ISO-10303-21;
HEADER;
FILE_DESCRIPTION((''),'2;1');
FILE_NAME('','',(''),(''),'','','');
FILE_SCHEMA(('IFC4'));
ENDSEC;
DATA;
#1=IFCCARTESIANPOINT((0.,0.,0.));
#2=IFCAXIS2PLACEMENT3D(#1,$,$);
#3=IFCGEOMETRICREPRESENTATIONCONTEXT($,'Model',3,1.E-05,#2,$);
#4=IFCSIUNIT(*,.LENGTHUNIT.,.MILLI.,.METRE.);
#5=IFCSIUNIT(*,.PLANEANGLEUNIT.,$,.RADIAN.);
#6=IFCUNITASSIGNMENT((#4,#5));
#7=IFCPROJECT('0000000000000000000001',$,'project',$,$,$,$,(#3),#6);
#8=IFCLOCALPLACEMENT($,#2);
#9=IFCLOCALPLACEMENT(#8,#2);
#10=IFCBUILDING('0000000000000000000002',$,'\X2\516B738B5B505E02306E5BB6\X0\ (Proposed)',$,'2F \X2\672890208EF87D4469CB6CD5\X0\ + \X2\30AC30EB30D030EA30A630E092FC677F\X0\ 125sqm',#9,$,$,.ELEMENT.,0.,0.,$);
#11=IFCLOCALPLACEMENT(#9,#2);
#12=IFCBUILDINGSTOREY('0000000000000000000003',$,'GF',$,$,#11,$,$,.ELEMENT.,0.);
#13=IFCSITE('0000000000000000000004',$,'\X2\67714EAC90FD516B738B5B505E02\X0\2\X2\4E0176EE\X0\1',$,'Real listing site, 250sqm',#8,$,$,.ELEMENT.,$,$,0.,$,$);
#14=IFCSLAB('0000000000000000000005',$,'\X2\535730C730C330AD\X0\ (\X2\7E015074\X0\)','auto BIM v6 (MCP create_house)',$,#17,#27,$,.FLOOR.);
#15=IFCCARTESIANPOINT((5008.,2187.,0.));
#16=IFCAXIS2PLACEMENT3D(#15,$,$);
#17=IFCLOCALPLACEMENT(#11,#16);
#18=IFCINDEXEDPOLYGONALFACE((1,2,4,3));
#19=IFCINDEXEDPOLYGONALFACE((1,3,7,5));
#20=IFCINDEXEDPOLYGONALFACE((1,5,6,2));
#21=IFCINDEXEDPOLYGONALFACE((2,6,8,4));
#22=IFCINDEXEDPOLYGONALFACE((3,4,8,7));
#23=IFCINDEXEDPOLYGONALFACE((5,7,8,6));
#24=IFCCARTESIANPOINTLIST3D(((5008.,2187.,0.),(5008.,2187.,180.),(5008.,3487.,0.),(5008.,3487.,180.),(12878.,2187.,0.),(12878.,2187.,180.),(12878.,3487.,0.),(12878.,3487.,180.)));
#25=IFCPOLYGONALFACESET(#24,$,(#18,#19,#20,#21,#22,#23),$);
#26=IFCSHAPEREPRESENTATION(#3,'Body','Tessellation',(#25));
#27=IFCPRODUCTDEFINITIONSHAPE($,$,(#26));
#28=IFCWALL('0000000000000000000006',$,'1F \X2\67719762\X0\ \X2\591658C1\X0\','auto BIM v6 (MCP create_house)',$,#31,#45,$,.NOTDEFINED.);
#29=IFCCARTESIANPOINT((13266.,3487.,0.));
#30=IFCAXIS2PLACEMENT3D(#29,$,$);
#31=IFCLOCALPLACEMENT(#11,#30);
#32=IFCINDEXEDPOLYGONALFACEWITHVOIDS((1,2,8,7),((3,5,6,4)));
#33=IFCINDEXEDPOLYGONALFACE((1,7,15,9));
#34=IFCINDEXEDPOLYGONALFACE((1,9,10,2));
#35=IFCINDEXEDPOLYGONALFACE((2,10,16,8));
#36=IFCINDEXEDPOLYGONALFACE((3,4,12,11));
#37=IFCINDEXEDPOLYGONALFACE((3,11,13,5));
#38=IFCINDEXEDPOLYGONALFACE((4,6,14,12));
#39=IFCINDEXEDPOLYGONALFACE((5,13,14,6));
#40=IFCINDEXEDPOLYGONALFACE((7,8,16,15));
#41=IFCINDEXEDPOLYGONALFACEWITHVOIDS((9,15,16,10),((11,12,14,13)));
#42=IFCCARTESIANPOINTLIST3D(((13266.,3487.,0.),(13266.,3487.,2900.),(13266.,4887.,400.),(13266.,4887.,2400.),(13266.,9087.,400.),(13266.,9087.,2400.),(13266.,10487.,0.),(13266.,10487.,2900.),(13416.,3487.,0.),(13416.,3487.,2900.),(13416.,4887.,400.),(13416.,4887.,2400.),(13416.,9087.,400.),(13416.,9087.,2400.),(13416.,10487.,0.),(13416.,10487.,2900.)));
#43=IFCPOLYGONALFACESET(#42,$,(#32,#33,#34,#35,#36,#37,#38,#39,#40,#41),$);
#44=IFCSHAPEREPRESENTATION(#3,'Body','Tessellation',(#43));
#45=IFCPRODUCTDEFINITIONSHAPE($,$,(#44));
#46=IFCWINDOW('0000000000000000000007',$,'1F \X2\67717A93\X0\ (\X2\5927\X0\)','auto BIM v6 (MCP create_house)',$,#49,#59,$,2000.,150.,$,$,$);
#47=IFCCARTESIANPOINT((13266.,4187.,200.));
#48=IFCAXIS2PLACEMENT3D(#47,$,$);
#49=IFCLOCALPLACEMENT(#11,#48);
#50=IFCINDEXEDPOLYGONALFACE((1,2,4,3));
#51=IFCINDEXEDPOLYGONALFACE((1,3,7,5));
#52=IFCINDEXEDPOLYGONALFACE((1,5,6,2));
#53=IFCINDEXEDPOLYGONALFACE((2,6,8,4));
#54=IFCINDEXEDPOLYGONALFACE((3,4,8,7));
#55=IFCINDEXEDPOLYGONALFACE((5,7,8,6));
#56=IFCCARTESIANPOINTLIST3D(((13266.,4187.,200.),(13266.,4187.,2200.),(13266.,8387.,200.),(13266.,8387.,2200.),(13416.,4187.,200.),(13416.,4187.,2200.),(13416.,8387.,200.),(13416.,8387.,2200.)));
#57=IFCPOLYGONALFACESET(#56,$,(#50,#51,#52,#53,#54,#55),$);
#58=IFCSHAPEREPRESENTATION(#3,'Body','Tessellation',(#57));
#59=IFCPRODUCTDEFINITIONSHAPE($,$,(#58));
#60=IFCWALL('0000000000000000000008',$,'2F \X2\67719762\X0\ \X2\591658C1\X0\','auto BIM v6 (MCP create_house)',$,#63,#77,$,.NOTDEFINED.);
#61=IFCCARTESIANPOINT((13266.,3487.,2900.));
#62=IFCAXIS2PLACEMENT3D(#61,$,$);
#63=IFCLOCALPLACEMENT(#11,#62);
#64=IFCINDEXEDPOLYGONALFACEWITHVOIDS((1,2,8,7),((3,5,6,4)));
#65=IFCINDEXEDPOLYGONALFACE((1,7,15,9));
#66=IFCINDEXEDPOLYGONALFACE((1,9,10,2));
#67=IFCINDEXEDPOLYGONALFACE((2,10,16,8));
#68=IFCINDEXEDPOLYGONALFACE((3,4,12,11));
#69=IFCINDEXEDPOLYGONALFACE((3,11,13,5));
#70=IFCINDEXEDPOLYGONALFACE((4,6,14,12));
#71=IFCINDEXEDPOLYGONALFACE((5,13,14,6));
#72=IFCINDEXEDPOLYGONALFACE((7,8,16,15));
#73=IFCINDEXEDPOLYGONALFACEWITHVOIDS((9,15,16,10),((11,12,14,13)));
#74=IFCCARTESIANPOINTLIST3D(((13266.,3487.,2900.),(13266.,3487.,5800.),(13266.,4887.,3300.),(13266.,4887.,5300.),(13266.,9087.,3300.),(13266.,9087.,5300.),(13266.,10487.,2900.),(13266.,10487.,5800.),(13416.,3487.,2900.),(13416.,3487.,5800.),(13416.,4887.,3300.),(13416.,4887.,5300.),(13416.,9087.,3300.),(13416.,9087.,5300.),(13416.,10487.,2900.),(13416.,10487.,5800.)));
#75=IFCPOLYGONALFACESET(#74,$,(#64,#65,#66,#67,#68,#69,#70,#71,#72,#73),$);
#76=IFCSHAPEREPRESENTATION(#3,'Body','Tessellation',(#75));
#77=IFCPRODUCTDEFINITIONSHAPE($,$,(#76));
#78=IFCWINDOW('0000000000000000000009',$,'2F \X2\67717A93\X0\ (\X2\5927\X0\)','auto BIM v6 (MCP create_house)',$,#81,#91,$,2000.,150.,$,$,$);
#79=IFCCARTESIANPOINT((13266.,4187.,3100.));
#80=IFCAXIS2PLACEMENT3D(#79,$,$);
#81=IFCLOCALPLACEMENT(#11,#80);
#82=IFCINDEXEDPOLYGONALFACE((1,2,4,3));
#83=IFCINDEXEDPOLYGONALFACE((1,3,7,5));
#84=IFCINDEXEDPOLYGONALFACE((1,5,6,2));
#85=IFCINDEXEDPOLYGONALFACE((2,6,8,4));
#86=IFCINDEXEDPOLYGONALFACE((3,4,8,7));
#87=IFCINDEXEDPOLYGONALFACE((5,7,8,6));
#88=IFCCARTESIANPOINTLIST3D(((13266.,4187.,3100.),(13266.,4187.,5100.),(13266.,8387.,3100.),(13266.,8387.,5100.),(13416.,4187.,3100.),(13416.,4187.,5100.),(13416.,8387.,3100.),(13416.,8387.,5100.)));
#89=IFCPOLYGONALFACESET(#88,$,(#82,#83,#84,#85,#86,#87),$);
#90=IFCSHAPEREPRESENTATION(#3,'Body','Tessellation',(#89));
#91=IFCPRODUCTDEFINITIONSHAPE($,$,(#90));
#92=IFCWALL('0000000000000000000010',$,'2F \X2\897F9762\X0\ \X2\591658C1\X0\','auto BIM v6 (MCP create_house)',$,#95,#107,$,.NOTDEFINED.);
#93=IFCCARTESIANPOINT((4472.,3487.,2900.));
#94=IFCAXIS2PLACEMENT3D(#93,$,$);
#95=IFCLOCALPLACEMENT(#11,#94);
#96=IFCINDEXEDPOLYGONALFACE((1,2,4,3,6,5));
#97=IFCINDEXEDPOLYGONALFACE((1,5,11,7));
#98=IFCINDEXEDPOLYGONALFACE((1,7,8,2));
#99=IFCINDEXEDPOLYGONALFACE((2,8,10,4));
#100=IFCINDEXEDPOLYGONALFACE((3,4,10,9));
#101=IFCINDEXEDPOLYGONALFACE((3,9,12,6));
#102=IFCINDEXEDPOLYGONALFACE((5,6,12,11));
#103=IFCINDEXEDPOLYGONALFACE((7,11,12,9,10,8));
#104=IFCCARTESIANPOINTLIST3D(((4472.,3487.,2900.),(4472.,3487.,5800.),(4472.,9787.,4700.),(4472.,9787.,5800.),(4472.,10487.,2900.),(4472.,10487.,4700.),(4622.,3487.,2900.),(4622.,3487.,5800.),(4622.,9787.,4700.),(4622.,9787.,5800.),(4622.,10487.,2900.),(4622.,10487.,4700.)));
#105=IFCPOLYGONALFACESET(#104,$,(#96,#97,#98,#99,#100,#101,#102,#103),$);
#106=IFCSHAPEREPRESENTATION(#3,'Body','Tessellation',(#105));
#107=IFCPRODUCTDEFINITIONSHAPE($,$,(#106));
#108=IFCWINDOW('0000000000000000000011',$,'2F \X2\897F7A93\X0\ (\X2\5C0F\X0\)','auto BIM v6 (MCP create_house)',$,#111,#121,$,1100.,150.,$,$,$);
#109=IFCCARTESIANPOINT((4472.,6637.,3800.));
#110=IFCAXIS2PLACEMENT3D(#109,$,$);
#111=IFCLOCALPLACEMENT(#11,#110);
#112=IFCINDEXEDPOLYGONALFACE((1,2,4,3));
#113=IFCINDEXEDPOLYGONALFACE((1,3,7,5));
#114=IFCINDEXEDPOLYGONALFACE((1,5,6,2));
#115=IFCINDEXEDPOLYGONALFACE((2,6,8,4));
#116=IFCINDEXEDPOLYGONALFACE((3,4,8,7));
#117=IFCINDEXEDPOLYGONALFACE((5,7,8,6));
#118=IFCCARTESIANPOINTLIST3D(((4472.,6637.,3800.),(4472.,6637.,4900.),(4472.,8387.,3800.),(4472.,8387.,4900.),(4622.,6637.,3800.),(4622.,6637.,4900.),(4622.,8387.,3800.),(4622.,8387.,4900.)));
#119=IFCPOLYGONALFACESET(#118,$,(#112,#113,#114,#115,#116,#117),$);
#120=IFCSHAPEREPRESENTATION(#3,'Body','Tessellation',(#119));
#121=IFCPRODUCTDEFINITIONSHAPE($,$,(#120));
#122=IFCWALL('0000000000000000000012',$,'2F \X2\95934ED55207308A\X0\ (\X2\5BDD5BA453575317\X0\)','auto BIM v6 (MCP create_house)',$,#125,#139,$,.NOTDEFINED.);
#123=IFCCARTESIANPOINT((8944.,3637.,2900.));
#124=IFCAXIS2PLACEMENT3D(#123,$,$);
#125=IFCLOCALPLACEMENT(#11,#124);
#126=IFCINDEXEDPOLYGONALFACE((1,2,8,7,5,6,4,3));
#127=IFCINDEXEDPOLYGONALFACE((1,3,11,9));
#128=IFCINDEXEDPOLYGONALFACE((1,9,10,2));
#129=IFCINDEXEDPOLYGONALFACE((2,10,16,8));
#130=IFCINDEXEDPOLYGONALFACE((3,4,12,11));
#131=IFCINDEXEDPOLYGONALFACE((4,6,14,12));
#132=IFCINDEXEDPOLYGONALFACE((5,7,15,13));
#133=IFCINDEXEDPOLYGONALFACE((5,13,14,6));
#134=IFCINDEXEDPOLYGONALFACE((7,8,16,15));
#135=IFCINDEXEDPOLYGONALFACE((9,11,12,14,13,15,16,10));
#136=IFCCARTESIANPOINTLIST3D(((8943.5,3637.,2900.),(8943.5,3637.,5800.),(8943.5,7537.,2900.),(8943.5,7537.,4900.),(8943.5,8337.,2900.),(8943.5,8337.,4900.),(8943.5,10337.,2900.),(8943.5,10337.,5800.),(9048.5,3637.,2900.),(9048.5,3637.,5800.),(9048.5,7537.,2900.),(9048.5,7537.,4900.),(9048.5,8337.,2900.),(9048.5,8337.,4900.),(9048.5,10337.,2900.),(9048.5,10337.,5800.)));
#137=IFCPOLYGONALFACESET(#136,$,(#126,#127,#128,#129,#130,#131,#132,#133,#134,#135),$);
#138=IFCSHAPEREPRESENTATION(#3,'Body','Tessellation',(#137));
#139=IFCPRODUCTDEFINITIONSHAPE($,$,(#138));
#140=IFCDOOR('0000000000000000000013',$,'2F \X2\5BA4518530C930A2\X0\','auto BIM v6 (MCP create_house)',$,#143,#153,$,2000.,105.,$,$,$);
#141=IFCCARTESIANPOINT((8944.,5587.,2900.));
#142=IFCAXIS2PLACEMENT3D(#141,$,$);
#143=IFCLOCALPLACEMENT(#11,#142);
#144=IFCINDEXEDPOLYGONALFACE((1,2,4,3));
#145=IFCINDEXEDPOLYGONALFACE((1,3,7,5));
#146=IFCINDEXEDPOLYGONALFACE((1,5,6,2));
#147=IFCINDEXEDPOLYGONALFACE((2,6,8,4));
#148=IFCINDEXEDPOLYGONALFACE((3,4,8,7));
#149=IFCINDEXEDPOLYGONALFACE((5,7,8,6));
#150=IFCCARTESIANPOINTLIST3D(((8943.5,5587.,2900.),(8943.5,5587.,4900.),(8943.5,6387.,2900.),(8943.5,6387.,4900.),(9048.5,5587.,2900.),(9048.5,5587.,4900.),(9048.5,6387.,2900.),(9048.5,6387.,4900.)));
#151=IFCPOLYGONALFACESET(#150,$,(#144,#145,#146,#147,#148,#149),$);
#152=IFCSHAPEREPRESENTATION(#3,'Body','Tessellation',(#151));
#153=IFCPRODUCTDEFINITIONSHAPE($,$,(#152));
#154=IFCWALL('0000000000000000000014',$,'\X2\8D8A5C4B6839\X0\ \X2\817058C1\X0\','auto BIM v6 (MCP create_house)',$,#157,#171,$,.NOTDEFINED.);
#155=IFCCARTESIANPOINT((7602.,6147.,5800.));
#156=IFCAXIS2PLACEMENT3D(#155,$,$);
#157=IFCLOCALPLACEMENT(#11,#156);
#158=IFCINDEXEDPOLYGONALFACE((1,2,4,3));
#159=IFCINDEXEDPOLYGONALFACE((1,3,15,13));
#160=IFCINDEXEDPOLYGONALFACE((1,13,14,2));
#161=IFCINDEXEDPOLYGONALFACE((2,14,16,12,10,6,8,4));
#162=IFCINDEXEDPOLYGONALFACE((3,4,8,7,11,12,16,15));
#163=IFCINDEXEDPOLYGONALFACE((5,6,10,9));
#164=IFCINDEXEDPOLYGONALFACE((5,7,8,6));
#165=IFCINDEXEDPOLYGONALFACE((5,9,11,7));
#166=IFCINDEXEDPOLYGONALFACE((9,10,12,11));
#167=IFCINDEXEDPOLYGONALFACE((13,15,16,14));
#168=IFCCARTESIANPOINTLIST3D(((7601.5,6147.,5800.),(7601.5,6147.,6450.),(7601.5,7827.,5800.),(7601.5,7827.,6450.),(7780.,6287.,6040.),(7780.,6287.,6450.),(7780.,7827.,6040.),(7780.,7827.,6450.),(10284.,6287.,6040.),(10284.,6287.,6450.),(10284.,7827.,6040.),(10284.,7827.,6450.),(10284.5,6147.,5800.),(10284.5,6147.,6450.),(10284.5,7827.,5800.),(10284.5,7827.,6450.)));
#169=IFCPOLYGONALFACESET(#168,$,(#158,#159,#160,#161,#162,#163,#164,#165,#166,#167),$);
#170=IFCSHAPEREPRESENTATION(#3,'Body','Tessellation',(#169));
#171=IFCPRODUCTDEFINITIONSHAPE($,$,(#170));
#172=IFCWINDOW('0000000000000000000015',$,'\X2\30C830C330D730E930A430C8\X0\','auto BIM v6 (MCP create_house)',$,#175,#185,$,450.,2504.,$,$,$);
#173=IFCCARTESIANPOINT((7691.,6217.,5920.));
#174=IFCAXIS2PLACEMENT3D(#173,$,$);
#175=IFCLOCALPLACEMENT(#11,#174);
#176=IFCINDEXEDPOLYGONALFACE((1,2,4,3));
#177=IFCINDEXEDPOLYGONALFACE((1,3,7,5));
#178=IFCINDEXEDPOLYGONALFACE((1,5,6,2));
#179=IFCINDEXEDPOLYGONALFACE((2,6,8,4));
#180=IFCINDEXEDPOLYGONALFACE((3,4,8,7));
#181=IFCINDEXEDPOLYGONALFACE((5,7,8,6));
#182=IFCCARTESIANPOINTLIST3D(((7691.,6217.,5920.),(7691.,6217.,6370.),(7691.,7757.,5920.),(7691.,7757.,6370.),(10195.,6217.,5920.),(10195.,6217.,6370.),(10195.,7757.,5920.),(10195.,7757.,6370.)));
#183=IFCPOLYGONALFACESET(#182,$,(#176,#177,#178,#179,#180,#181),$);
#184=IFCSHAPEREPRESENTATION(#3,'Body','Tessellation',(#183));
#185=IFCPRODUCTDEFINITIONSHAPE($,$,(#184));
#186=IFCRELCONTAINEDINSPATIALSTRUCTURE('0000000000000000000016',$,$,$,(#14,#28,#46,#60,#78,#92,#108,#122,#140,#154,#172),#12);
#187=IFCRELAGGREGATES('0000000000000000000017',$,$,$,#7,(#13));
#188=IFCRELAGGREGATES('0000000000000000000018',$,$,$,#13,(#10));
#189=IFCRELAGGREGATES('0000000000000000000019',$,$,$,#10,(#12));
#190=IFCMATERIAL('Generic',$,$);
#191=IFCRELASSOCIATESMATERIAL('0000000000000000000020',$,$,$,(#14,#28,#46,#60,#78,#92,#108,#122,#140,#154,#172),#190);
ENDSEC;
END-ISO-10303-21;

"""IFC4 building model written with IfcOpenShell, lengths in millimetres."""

from ifc_helpers import new_model, si_unit, frame, frame_2d, origin, place, context, project, spatial, rectangle, extrude, material, element, fill, save


model = new_model("IFC4")

# Units and contexts
model_context = context("Model", 3, precision=1e-05, world=origin())
ifc_project = project(units=[si_unit("LENGTHUNIT", "METRE", prefix="MILLI"), si_unit("PLANEANGLEUNIT", "RADIAN")], contexts=[model_context])

# Site, building, storey
site_placement = place(None, origin())
site = spatial("IfcSite", under=ifc_project, at=site_placement, Name="東京都八王子市2丁目1", ObjectType="Real listing site, 250sqm", CompositionType="ELEMENT", RefElevation=0.0)
building_placement = place(site_placement, origin())
building = spatial("IfcBuilding", under=site, at=building_placement, Name="八王子市の家 (Proposed)", ObjectType="2F 木造軸組構法 + ガルバリウム鋼板 125sqm", CompositionType="ELEMENT", ElevationOfRefHeight=0.0, ElevationOfTerrain=0.0)
storey_placement = place(building_placement, origin())
storey = spatial("IfcBuildingStorey", under=building, at=storey_placement, Name="GF", CompositionType="ELEMENT", Elevation=0.0)

# Slab
ifc_material = material(Name="Generic")
slab_placement = place(storey_placement, frame((5008.0, 2187.0, 0.0)))
element("IfcSlab", 1, at=slab_placement, inside=storey, material=ifc_material, Name="南デッキ (縁側)", Description="auto BIM v6 (MCP create_house)", PredefinedType="FLOOR", context=model_context, shape_type="SweptSolid", body=[
    extrude(rectangle(XDim=7870.0, YDim=1300.0, at=frame_2d((3935.0, 650.0))), frame((5008.0, 2187.0, 0.0)), (0.0, 0.0, 1.0), 180.0),
])

# Wall, opening, window
wall_1_placement = place(storey_placement, frame((13266.0, 3487.0, 0.0)))
wall_1 = element("IfcWall", 2, at=wall_1_placement, inside=storey, material=ifc_material, Name="1F 東面 外壁", Description="auto BIM v6 (MCP create_house)", PredefinedType="NOTDEFINED", context=model_context, shape_type="SweptSolid", body=[
    extrude(rectangle(XDim=150.0, YDim=7000.0, at=frame_2d((75.0, 3500.0))), frame((13266.0, 3487.0, 0.0)), (0.0, 0.0, 1.0), 2900.0),
])
opening_1_placement = place(storey_placement, frame((13266.0, 4187.0, 200.0)))
opening_1 = element("IfcOpeningElement", 3, at=opening_1_placement, cuts=wall_1, PredefinedType="NOTDEFINED", context=model_context, shape_type="SweptSolid", body=[
    extrude(rectangle(XDim=150.0, YDim=4200.0, at=frame_2d((75.0, 2100.0))), frame((13266.0, 4187.0, 200.0)), (0.0, 0.0, 1.0), 2000.0),
])
window_1_placement = place(storey_placement, frame((13266.0, 4187.0, 200.0)))
window_1 = element("IfcWindow", 4, at=window_1_placement, inside=storey, material=ifc_material, Name="1F 東窓 (大)", Description="auto BIM v6 (MCP create_house)", OverallHeight=2000.0, OverallWidth=150.0, context=model_context, shape_type="SweptSolid", body=[
    extrude(rectangle(XDim=150.0, YDim=4200.0, at=frame_2d((75.0, 2100.0))), frame((13266.0, 4187.0, 200.0)), (0.0, 0.0, 1.0), 2000.0),
])
fill(opening_1, window_1)

# Walls, openings, windows
wall_2_placement = place(storey_placement, frame((13266.0, 3487.0, 2900.0)))
wall_2 = element("IfcWall", 5, at=wall_2_placement, inside=storey, material=ifc_material, Name="2F 東面 外壁", Description="auto BIM v6 (MCP create_house)", PredefinedType="NOTDEFINED", context=model_context, shape_type="SweptSolid", body=[
    extrude(rectangle(XDim=150.0, YDim=7000.0, at=frame_2d((75.0, 3500.0))), frame((13266.0, 3487.0, 2900.0)), (0.0, 0.0, 1.0), 2900.0),
])
opening_2_placement = place(storey_placement, frame((13266.0, 4187.0, 3100.0)))
opening_2 = element("IfcOpeningElement", 6, at=opening_2_placement, cuts=wall_2, PredefinedType="NOTDEFINED", context=model_context, shape_type="SweptSolid", body=[
    extrude(rectangle(XDim=150.0, YDim=4200.0, at=frame_2d((75.0, 2100.0))), frame((13266.0, 4187.0, 3100.0)), (0.0, 0.0, 1.0), 2000.0),
])
window_2_placement = place(storey_placement, frame((13266.0, 4187.0, 3100.0)))
window_2 = element("IfcWindow", 7, at=window_2_placement, inside=storey, material=ifc_material, Name="2F 東窓 (大)", Description="auto BIM v6 (MCP create_house)", OverallHeight=2000.0, OverallWidth=150.0, context=model_context, shape_type="SweptSolid", body=[
    extrude(rectangle(XDim=150.0, YDim=4200.0, at=frame_2d((75.0, 2100.0))), frame((13266.0, 4187.0, 3100.0)), (0.0, 0.0, 1.0), 2000.0),
])
fill(opening_2, window_2)
wall_3_placement = place(storey_placement, frame((4472.0, 3487.0, 2900.0)))
wall_3 = element("IfcWall", 8, at=wall_3_placement, inside=storey, material=ifc_material, Name="2F 西面 外壁", Description="auto BIM v6 (MCP create_house)", PredefinedType="NOTDEFINED", context=model_context, shape_type="SweptSolid", body=[
    extrude(rectangle(XDim=150.0, YDim=7000.0, at=frame_2d((75.0, 3500.0))), frame((4472.0, 3487.0, 2900.0)), (0.0, 0.0, 1.0), 2900.0),
])
opening_3_placement = place(storey_placement, frame((4472.0, 6637.0, 3800.0)))
opening_3 = element("IfcOpeningElement", 9, at=opening_3_placement, cuts=wall_3, PredefinedType="NOTDEFINED", context=model_context, shape_type="SweptSolid", body=[
    extrude(rectangle(XDim=150.0, YDim=1750.0, at=frame_2d((75.0, 875.0))), frame((4472.0, 6637.0, 3800.0)), (0.0, 0.0, 1.0), 1100.0),
])
window_3_placement = place(storey_placement, frame((4472.0, 6637.0, 3800.0)))
window_3 = element("IfcWindow", 10, at=window_3_placement, inside=storey, material=ifc_material, Name="2F 西窓 (小)", Description="auto BIM v6 (MCP create_house)", OverallHeight=1100.0, OverallWidth=150.0, context=model_context, shape_type="SweptSolid", body=[
    extrude(rectangle(XDim=150.0, YDim=1750.0, at=frame_2d((75.0, 875.0))), frame((4472.0, 6637.0, 3800.0)), (0.0, 0.0, 1.0), 1100.0),
])
fill(opening_3, window_3)

# Wall, opening, door
wall_4_placement = place(storey_placement, frame((8944.0, 3637.0, 2900.0)))
wall_4 = element("IfcWall", 11, at=wall_4_placement, inside=storey, material=ifc_material, Name="2F 間仕切り (寝室南北)", Description="auto BIM v6 (MCP create_house)", PredefinedType="NOTDEFINED", context=model_context, shape_type="SweptSolid", body=[
    extrude(rectangle(XDim=105.0, YDim=6700.0, at=frame_2d((52.0, 3350.0))), frame((8944.0, 3637.0, 2900.0)), (0.0, 0.0, 1.0), 2900.0),
])
opening_4_placement = place(storey_placement, frame((8944.0, 5587.0, 2900.0)))
opening_4 = element("IfcOpeningElement", 12, at=opening_4_placement, cuts=wall_4, PredefinedType="NOTDEFINED", context=model_context, shape_type="SweptSolid", body=[
    extrude(rectangle(XDim=105.0, YDim=800.0, at=frame_2d((52.0, 400.0))), frame((8944.0, 5587.0, 2900.0)), (0.0, 0.0, 1.0), 2000.0),
])
door_placement = place(storey_placement, frame((8944.0, 5587.0, 2900.0)))
door = element("IfcDoor", 13, at=door_placement, inside=storey, material=ifc_material, Name="2F 室内ドア", Description="auto BIM v6 (MCP create_house)", OverallHeight=2000.0, OverallWidth=105.0, context=model_context, shape_type="SweptSolid", body=[
    extrude(rectangle(XDim=105.0, YDim=800.0, at=frame_2d((52.0, 400.0))), frame((8944.0, 5587.0, 2900.0)), (0.0, 0.0, 1.0), 2000.0),
])
fill(opening_4, door)

# Wall, opening, window
wall_5_placement = place(storey_placement, frame((7602.0, 6147.0, 5800.0)))
wall_5 = element("IfcWall", 14, at=wall_5_placement, inside=storey, material=ifc_material, Name="越屋根 腰壁", Description="auto BIM v6 (MCP create_house)", PredefinedType="NOTDEFINED", context=model_context, shape_type="SweptSolid", body=[
    extrude(rectangle(XDim=2683.0, YDim=1680.0, at=frame_2d((1341.0, 840.0))), frame((7602.0, 6147.0, 5800.0)), (0.0, 0.0, 1.0), 650.0),
])
opening_5_placement = place(storey_placement, frame((7691.0, 6217.0, 5920.0)))
opening_5 = element("IfcOpeningElement", 15, at=opening_5_placement, cuts=wall_5, PredefinedType="NOTDEFINED", context=model_context, shape_type="SweptSolid", body=[
    extrude(rectangle(XDim=2504.0, YDim=1540.0, at=frame_2d((1252.0, 770.0))), frame((7691.0, 6217.0, 5920.0)), (0.0, 0.0, 1.0), 450.0),
])
window_4_placement = place(storey_placement, frame((7691.0, 6217.0, 5920.0)))
window_4 = element("IfcWindow", 16, at=window_4_placement, inside=storey, material=ifc_material, Name="トップライト", Description="auto BIM v6 (MCP create_house)", OverallHeight=450.0, OverallWidth=2504.0, context=model_context, shape_type="SweptSolid", body=[
    extrude(rectangle(XDim=2504.0, YDim=1540.0, at=frame_2d((1252.0, 770.0))), frame((7691.0, 6217.0, 5920.0)), (0.0, 0.0, 1.0), 450.0),
])
fill(opening_5, window_4)

save(model, "model.ifc")
